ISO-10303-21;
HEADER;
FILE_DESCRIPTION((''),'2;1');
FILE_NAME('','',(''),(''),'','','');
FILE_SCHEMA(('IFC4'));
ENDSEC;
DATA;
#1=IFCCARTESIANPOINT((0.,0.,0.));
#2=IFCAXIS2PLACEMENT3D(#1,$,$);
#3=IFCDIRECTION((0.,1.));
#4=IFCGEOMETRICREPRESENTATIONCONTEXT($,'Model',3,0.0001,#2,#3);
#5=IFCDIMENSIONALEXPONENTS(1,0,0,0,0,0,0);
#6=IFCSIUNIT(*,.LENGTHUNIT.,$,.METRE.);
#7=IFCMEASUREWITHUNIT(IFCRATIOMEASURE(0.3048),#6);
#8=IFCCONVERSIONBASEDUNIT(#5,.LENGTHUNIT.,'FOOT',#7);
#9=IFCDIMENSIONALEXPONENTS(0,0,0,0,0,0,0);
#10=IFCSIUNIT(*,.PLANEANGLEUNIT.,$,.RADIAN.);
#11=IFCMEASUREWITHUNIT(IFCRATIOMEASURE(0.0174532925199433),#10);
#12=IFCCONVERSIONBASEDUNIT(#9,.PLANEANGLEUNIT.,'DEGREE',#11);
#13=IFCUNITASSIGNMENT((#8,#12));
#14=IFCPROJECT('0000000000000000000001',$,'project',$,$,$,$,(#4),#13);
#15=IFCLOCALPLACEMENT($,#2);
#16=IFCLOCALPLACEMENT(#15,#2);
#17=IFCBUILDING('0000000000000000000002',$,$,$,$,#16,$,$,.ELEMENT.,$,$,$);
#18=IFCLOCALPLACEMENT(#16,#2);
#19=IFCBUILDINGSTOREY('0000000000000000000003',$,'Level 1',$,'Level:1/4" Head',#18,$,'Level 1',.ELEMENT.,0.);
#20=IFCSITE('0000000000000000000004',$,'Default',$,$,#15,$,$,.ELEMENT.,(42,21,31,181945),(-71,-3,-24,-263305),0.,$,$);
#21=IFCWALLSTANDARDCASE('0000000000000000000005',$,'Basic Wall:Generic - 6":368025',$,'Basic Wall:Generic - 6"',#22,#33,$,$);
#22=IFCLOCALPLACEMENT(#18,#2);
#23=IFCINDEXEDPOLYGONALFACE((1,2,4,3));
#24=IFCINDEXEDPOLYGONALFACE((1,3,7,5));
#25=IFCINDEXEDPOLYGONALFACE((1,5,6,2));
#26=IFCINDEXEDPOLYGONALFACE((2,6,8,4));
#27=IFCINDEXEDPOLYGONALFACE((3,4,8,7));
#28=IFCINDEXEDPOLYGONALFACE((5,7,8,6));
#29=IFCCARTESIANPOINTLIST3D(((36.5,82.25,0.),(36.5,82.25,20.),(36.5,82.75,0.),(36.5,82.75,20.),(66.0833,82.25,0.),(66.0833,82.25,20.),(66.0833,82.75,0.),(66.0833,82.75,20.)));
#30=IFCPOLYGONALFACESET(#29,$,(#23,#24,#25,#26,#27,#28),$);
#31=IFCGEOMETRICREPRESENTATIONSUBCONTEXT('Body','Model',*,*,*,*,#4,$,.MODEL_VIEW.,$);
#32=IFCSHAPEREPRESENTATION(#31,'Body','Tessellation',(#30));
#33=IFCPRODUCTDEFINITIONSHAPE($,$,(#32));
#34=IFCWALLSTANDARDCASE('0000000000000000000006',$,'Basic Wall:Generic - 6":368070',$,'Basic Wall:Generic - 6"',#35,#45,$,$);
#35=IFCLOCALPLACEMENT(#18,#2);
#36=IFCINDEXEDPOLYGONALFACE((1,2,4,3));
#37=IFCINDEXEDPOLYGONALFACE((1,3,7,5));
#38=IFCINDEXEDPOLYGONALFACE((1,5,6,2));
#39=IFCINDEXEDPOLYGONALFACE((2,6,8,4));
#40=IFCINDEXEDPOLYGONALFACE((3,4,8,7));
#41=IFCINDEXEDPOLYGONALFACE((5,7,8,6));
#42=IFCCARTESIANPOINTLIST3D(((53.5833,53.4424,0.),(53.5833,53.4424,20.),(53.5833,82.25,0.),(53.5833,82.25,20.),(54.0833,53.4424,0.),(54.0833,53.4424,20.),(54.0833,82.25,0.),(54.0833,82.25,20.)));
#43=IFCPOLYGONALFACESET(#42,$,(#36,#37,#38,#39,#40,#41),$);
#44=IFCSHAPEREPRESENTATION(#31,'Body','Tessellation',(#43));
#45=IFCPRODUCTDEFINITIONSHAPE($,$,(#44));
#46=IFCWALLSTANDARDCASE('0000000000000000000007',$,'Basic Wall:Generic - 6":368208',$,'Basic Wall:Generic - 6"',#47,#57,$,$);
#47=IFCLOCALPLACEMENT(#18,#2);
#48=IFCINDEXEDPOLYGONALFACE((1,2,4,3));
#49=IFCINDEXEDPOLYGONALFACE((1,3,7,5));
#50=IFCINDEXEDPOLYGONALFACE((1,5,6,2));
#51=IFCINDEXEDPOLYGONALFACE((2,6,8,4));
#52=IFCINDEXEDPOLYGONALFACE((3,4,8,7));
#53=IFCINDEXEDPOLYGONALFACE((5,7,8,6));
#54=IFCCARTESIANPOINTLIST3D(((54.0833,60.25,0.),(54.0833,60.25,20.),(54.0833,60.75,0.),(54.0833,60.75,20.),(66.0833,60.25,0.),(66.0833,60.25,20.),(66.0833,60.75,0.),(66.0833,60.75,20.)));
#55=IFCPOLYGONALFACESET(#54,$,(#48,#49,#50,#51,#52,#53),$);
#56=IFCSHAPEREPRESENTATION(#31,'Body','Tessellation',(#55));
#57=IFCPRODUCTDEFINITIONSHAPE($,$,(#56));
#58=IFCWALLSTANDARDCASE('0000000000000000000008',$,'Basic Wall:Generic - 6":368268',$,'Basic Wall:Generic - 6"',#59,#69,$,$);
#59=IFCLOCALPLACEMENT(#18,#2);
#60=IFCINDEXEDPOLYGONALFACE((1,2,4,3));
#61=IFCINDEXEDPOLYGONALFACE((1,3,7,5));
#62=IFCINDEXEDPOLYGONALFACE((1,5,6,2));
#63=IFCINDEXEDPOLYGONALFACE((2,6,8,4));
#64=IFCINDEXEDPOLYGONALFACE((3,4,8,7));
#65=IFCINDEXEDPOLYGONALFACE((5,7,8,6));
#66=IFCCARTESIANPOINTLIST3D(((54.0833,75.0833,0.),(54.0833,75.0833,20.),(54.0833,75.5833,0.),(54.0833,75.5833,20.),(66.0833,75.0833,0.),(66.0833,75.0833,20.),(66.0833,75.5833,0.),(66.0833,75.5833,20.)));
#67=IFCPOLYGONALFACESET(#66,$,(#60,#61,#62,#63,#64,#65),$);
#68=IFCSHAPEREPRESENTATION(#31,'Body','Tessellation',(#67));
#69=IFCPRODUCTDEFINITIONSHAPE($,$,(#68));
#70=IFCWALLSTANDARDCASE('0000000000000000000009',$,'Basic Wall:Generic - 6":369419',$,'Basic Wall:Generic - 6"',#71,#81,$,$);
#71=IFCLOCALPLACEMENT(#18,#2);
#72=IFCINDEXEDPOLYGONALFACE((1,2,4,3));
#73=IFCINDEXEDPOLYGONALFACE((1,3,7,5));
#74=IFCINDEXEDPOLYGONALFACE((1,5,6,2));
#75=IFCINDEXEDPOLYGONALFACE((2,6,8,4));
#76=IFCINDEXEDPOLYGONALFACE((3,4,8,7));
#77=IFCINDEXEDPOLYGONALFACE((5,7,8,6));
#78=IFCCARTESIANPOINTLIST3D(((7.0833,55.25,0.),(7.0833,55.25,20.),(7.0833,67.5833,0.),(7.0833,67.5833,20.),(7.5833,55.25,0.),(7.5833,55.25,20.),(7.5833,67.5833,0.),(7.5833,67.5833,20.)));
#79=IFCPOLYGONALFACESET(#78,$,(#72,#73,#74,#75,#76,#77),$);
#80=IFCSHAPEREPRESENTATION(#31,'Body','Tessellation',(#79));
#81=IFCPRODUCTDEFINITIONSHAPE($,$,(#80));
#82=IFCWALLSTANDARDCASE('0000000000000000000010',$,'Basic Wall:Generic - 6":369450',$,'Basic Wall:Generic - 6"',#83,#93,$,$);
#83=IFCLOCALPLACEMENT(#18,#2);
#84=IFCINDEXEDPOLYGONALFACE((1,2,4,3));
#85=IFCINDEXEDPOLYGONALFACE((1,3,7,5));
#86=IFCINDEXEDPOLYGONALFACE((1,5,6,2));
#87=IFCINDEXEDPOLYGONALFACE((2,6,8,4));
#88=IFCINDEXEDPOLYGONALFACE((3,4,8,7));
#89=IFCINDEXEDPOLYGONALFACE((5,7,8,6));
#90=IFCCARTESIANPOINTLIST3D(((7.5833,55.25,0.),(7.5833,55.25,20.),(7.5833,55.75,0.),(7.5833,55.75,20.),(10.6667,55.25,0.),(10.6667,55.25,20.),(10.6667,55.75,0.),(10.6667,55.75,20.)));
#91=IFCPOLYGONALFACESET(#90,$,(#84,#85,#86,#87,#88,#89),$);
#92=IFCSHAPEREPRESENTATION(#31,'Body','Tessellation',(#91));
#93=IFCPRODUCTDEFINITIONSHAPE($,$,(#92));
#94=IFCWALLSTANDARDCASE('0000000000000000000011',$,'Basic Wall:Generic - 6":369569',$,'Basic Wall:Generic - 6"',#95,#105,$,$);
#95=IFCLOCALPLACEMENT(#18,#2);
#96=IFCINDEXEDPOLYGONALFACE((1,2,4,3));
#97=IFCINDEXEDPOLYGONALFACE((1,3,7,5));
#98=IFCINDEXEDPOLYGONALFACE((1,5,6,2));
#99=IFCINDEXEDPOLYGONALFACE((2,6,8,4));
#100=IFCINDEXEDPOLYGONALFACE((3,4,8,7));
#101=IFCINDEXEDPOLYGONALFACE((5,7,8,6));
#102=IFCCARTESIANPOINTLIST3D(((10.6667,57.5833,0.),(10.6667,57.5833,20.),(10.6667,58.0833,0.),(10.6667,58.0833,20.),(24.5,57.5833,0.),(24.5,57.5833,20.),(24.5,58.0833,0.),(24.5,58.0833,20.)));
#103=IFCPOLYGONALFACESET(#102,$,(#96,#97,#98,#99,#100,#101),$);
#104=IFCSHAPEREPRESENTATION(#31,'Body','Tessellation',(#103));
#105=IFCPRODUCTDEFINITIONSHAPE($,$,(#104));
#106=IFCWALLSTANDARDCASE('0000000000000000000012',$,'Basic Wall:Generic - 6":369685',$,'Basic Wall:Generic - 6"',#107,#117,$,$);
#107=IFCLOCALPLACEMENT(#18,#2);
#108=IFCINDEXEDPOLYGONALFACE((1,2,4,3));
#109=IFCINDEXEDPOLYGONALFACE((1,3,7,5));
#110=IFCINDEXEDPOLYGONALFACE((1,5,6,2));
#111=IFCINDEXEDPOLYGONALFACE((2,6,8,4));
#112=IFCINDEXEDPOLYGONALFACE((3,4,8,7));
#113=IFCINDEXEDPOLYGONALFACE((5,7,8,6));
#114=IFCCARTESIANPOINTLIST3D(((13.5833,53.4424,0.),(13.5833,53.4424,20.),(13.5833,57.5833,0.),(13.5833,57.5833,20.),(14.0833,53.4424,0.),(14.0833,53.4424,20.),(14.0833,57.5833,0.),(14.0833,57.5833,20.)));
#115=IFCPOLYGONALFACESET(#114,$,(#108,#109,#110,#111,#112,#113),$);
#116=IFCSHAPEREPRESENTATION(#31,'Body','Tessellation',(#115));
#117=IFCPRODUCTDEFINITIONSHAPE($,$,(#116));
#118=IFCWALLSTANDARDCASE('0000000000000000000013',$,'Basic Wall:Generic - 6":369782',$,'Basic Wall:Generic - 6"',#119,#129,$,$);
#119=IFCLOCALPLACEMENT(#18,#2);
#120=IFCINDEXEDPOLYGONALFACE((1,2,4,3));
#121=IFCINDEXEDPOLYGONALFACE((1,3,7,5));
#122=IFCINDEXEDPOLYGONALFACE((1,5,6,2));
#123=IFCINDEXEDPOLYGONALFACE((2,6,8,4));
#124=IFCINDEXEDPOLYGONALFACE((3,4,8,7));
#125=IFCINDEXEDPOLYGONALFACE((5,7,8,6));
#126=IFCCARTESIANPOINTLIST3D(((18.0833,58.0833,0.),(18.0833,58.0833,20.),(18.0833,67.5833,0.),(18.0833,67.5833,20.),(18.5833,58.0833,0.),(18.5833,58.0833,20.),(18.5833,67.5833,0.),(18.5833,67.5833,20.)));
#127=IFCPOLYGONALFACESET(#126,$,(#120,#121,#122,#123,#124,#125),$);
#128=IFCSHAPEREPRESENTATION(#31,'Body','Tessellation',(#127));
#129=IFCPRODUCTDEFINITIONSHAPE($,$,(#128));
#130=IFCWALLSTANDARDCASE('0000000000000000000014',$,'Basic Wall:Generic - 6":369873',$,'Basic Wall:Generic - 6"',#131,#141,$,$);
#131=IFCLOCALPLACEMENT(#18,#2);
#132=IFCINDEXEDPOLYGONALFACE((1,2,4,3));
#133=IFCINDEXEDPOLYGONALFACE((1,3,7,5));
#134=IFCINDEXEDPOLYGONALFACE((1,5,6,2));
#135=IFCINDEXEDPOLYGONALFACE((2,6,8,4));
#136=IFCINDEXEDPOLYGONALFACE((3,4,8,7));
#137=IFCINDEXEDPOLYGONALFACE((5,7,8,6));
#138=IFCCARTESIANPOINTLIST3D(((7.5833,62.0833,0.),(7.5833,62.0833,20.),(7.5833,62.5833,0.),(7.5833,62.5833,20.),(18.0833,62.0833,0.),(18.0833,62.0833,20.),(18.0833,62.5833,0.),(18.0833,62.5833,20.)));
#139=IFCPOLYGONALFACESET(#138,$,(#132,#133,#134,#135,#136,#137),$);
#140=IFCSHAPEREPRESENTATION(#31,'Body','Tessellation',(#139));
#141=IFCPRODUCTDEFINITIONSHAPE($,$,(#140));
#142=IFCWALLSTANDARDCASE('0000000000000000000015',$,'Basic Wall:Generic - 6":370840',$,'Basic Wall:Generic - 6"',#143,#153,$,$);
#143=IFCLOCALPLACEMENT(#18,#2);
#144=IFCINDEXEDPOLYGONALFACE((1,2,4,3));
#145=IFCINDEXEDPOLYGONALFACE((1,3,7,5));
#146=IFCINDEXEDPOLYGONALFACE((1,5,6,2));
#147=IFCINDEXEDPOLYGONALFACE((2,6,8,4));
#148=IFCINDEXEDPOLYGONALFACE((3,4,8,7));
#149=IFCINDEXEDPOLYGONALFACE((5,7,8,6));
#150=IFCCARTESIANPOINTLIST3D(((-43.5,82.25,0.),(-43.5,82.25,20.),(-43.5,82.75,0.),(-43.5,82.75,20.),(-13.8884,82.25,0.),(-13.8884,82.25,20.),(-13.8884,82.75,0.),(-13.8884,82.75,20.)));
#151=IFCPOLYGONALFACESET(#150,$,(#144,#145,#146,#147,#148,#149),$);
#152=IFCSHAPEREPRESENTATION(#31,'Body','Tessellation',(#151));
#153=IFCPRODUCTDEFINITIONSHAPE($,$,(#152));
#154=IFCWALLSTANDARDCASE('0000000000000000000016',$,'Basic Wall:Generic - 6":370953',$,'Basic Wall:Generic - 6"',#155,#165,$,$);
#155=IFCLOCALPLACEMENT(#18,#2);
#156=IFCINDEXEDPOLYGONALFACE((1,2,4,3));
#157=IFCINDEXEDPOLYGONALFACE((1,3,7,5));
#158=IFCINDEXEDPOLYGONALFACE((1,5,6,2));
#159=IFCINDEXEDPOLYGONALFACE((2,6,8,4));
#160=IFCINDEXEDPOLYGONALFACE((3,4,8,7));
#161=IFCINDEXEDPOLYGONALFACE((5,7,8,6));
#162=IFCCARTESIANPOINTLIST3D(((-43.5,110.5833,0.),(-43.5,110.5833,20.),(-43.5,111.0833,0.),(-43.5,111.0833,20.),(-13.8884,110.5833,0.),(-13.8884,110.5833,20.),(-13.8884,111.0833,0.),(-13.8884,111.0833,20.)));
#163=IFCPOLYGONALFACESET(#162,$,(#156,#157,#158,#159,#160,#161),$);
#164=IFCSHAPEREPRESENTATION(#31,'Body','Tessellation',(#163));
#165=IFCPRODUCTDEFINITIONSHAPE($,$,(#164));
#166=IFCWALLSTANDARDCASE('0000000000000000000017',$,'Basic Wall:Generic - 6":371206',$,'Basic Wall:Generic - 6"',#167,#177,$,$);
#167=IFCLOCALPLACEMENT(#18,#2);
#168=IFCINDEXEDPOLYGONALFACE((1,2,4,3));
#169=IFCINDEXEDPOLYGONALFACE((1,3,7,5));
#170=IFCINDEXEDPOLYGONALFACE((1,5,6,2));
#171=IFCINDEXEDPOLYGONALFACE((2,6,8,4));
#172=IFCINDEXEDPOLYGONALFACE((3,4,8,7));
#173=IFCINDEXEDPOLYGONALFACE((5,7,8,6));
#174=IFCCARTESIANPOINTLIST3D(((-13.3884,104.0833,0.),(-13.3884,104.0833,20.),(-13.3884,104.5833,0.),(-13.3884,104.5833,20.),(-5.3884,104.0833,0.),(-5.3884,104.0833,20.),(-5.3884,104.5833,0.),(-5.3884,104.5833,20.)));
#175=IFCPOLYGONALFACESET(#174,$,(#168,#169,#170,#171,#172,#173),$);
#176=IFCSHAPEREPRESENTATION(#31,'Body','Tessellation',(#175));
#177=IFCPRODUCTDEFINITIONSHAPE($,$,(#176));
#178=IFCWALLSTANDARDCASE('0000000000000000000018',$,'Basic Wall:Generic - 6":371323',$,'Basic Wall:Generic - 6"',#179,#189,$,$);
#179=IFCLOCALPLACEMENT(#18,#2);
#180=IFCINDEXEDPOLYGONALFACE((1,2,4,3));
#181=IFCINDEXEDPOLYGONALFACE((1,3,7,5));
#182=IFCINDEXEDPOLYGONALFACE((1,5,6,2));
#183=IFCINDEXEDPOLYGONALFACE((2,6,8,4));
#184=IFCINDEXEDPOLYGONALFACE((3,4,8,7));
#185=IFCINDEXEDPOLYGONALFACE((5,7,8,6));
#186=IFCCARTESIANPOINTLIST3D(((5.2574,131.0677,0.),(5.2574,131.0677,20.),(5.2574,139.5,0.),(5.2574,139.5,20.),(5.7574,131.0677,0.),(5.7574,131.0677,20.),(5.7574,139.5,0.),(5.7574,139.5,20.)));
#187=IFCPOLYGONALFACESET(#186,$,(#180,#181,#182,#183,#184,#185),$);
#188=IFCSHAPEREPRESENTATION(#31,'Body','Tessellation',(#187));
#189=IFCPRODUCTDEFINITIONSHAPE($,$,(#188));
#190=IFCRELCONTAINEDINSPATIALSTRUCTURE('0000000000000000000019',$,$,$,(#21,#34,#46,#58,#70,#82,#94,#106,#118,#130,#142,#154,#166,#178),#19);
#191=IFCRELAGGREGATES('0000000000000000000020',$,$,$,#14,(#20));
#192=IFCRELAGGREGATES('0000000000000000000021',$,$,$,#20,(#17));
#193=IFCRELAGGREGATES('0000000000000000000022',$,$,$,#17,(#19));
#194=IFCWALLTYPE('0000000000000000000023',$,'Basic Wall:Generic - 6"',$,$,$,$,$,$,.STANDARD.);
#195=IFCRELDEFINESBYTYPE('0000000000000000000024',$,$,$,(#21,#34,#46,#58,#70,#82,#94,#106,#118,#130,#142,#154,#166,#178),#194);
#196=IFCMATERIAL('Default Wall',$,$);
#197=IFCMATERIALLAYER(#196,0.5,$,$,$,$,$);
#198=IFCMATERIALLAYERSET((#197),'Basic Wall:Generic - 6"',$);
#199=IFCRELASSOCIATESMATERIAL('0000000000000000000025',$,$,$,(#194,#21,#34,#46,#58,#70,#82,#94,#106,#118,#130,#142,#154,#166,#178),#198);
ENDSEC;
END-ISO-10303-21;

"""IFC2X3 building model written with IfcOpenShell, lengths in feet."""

from ifc_helpers import new_model, entity, si_unit, converted_unit, direction, frame, frame_2d, origin, place, context, subcontext, project, spatial, rectangle, extrude, material, layer, layer_set, layer_usage, type_object, element, save


model = new_model("IFC2X3")

# Units and contexts
model_context = context("Model", 3, precision=0.0001, world=origin(), true_north=direction((0.0, 1.0)))
body_context = subcontext(model_context, "Body", "Model", "MODEL_VIEW")
ifc_project = project(units=[converted_unit("LENGTHUNIT", "FOOT", entity("IfcRatioMeasure", 0.3048), si_unit("LENGTHUNIT", "METRE"), dimensions=[1, 0, 0, 0, 0, 0, 0]), converted_unit("PLANEANGLEUNIT", "DEGREE", entity("IfcRatioMeasure", 0.0174532925199433), si_unit("PLANEANGLEUNIT", "RADIAN"), dimensions=[0, 0, 0, 0, 0, 0, 0])], contexts=[model_context])

# Site, building, storey
site_placement = place(None, origin())
site = spatial("IfcSite", under=ifc_project, at=site_placement, Name="Default", CompositionType="ELEMENT", RefLatitude=(42, 21, 31, 181945), RefLongitude=(-71, -3, -24, -263305), RefElevation=0.0)
building_placement = place(site_placement, origin())
building = spatial("IfcBuilding", under=site, at=building_placement, CompositionType="ELEMENT")
storey_placement = place(building_placement, origin())
storey = spatial("IfcBuildingStorey", under=building, at=storey_placement, Name="Level 1", ObjectType="Level:1/4\" Head", LongName="Level 1", CompositionType="ELEMENT", Elevation=0.0)

# Walls
ifc_material = material(Name="Default Wall")
ifc_layer_1 = layer(ifc_material, 0.5)
ifc_layer_set_1 = layer_set([ifc_layer_1], Name="Basic Wall:Generic - 6\"")
wall_type_1 = type_object("IfcWallType", Name="Basic Wall:Generic - 6\"", PredefinedType="STANDARD", material=ifc_layer_set_1)
ifc_layer_usage_1 = layer_usage(ifc_layer_set_1, "AXIS2", "NEGATIVE", 0.25)
wall_1_placement = place(storey_placement, frame((36.5, 82.5, 0.0)))
element("IfcWallStandardCase", 1, at=wall_1_placement, inside=storey, type_object=wall_type_1, material=ifc_layer_usage_1, Name="Basic Wall:Generic - 6\":368025", ObjectType="Basic Wall:Generic - 6\"", context=body_context, shape_type="SweptSolid", body=[
    extrude(rectangle(XDim=29.5833, YDim=0.5, at=frame_2d((14.7917, 0.0), x_axis=(-1.0, 0.0))), origin(), (0.0, 0.0, 1.0), 20.0),
])
ifc_layer_usage_2 = layer_usage(ifc_layer_set_1, "AXIS2", "NEGATIVE", 0.25)
wall_2_placement = place(storey_placement, frame((53.8333, 82.25, 0.0), z_axis=(0.0, 0.0, 1.0), x_axis=(0.0, -1.0, 0.0)))
element("IfcWallStandardCase", 2, at=wall_2_placement, inside=storey, type_object=wall_type_1, material=ifc_layer_usage_2, Name="Basic Wall:Generic - 6\":368070", ObjectType="Basic Wall:Generic - 6\"", context=body_context, shape_type="SweptSolid", body=[
    extrude(rectangle(XDim=28.8076, YDim=0.5, at=frame_2d((14.4038, 0.0), x_axis=(-1.0, 0.0))), origin(), (0.0, 0.0, 1.0), 20.0),
])
ifc_layer_usage_3 = layer_usage(ifc_layer_set_1, "AXIS2", "NEGATIVE", 0.25)
wall_3_placement = place(storey_placement, frame((54.0833, 60.5, 0.0)))
element("IfcWallStandardCase", 3, at=wall_3_placement, inside=storey, type_object=wall_type_1, material=ifc_layer_usage_3, Name="Basic Wall:Generic - 6\":368208", ObjectType="Basic Wall:Generic - 6\"", context=body_context, shape_type="SweptSolid", body=[
    extrude(rectangle(XDim=12.0, YDim=0.5, at=frame_2d((6.0, 0.0), x_axis=(-1.0, 0.0))), origin(), (0.0, 0.0, 1.0), 20.0),
])
ifc_layer_usage_4 = layer_usage(ifc_layer_set_1, "AXIS2", "NEGATIVE", 0.25)
wall_4_placement = place(storey_placement, frame((54.0833, 75.3333, 0.0)))
element("IfcWallStandardCase", 4, at=wall_4_placement, inside=storey, type_object=wall_type_1, material=ifc_layer_usage_4, Name="Basic Wall:Generic - 6\":368268", ObjectType="Basic Wall:Generic - 6\"", context=body_context, shape_type="SweptSolid", body=[
    extrude(rectangle(XDim=12.0, YDim=0.5, at=frame_2d((6.0, 0.0), x_axis=(-1.0, 0.0))), origin(), (0.0, 0.0, 1.0), 20.0),
])
ifc_layer_usage_5 = layer_usage(ifc_layer_set_1, "AXIS2", "NEGATIVE", 0.25)
wall_5_placement = place(storey_placement, frame((7.3333, 67.5833, 0.0), z_axis=(0.0, 0.0, 1.0), x_axis=(0.0, -1.0, 0.0)))
element("IfcWallStandardCase", 5, at=wall_5_placement, inside=storey, type_object=wall_type_1, material=ifc_layer_usage_5, Name="Basic Wall:Generic - 6\":369419", ObjectType="Basic Wall:Generic - 6\"", context=body_context, shape_type="SweptSolid", body=[
    extrude(rectangle(XDim=12.3333, YDim=0.5, at=frame_2d((6.1667, 0.0), x_axis=(-1.0, 0.0))), origin(), (0.0, 0.0, 1.0), 20.0),
])
ifc_layer_usage_6 = layer_usage(ifc_layer_set_1, "AXIS2", "NEGATIVE", 0.25)
wall_6_placement = place(storey_placement, frame((7.5833, 55.5, 0.0)))
element("IfcWallStandardCase", 6, at=wall_6_placement, inside=storey, type_object=wall_type_1, material=ifc_layer_usage_6, Name="Basic Wall:Generic - 6\":369450", ObjectType="Basic Wall:Generic - 6\"", context=body_context, shape_type="SweptSolid", body=[
    extrude(rectangle(XDim=3.0833, YDim=0.5, at=frame_2d((1.5417, 0.0), x_axis=(-1.0, 0.0))), origin(), (0.0, 0.0, 1.0), 20.0),
])
ifc_layer_usage_7 = layer_usage(ifc_layer_set_1, "AXIS2", "NEGATIVE", 0.25)
wall_7_placement = place(storey_placement, frame((10.6667, 57.8333, 0.0)))
element("IfcWallStandardCase", 7, at=wall_7_placement, inside=storey, type_object=wall_type_1, material=ifc_layer_usage_7, Name="Basic Wall:Generic - 6\":369569", ObjectType="Basic Wall:Generic - 6\"", context=body_context, shape_type="SweptSolid", body=[
    extrude(rectangle(XDim=13.8333, YDim=0.5, at=frame_2d((6.9167, 0.0), x_axis=(-1.0, 0.0))), origin(), (0.0, 0.0, 1.0), 20.0),
])
ifc_layer_usage_8 = layer_usage(ifc_layer_set_1, "AXIS2", "NEGATIVE", 0.25)
wall_8_placement = place(storey_placement, frame((13.8333, 57.5833, 0.0), z_axis=(0.0, 0.0, 1.0), x_axis=(0.0, -1.0, 0.0)))
element("IfcWallStandardCase", 8, at=wall_8_placement, inside=storey, type_object=wall_type_1, material=ifc_layer_usage_8, Name="Basic Wall:Generic - 6\":369685", ObjectType="Basic Wall:Generic - 6\"", context=body_context, shape_type="SweptSolid", body=[
    extrude(rectangle(XDim=4.141, YDim=0.5, at=frame_2d((2.0705, 0.0), x_axis=(-1.0, 0.0))), origin(), (0.0, 0.0, 1.0), 20.0),
])
ifc_layer_usage_9 = layer_usage(ifc_layer_set_1, "AXIS2", "NEGATIVE", 0.25)
wall_9_placement = place(storey_placement, frame((18.3333, 67.5833, 0.0), z_axis=(0.0, 0.0, 1.0), x_axis=(0.0, -1.0, 0.0)))
element("IfcWallStandardCase", 9, at=wall_9_placement, inside=storey, type_object=wall_type_1, material=ifc_layer_usage_9, Name="Basic Wall:Generic - 6\":369782", ObjectType="Basic Wall:Generic - 6\"", context=body_context, shape_type="SweptSolid", body=[
    extrude(rectangle(XDim=9.5, YDim=0.5, at=frame_2d((4.75, 0.0), x_axis=(-1.0, 0.0))), origin(), (0.0, 0.0, 1.0), 20.0),
])
ifc_layer_usage_10 = layer_usage(ifc_layer_set_1, "AXIS2", "NEGATIVE", 0.25)
wall_10_placement = place(storey_placement, frame((7.5833, 62.3333, 0.0)))
element("IfcWallStandardCase", 10, at=wall_10_placement, inside=storey, type_object=wall_type_1, material=ifc_layer_usage_10, Name="Basic Wall:Generic - 6\":369873", ObjectType="Basic Wall:Generic - 6\"", context=body_context, shape_type="SweptSolid", body=[
    extrude(rectangle(XDim=10.5, YDim=0.5, at=frame_2d((5.25, 0.0), x_axis=(-1.0, 0.0))), origin(), (0.0, 0.0, 1.0), 20.0),
])
ifc_layer_usage_11 = layer_usage(ifc_layer_set_1, "AXIS2", "NEGATIVE", 0.25)
wall_11_placement = place(storey_placement, frame((-13.8884, 82.5, 0.0), z_axis=(0.0, 0.0, 1.0), x_axis=(-1.0, 0.0, 0.0)))
element("IfcWallStandardCase", 11, at=wall_11_placement, inside=storey, type_object=wall_type_1, material=ifc_layer_usage_11, Name="Basic Wall:Generic - 6\":370840", ObjectType="Basic Wall:Generic - 6\"", context=body_context, shape_type="SweptSolid", body=[
    extrude(rectangle(XDim=29.6116, YDim=0.5, at=frame_2d((14.8058, 0.0), x_axis=(-1.0, 0.0))), origin(), (0.0, 0.0, 1.0), 20.0),
])
ifc_layer_usage_12 = layer_usage(ifc_layer_set_1, "AXIS2", "NEGATIVE", 0.25)
wall_12_placement = place(storey_placement, frame((-13.8884, 110.8333, 0.0), z_axis=(0.0, 0.0, 1.0), x_axis=(-1.0, 0.0, 0.0)))
element("IfcWallStandardCase", 12, at=wall_12_placement, inside=storey, type_object=wall_type_1, material=ifc_layer_usage_12, Name="Basic Wall:Generic - 6\":370953", ObjectType="Basic Wall:Generic - 6\"", context=body_context, shape_type="SweptSolid", body=[
    extrude(rectangle(XDim=29.6116, YDim=0.5, at=frame_2d((14.8058, 0.0), x_axis=(-1.0, 0.0))), origin(), (0.0, 0.0, 1.0), 20.0),
])
ifc_layer_usage_13 = layer_usage(ifc_layer_set_1, "AXIS2", "NEGATIVE", 0.25)
wall_13_placement = place(storey_placement, frame((-13.3884, 104.3333, 0.0)))
element("IfcWallStandardCase", 13, at=wall_13_placement, inside=storey, type_object=wall_type_1, material=ifc_layer_usage_13, Name="Basic Wall:Generic - 6\":371206", ObjectType="Basic Wall:Generic - 6\"", context=body_context, shape_type="SweptSolid", body=[
    extrude(rectangle(XDim=8.0, YDim=0.5, at=frame_2d((4.0, 0.0), x_axis=(-1.0, 0.0))), origin(), (0.0, 0.0, 1.0), 20.0),
])
ifc_layer_usage_14 = layer_usage(ifc_layer_set_1, "AXIS2", "NEGATIVE", 0.25)
wall_14_placement = place(storey_placement, frame((5.5074, 139.5, 0.0), z_axis=(0.0, 0.0, 1.0), x_axis=(0.0, -1.0, 0.0)))
element("IfcWallStandardCase", 14, at=wall_14_placement, inside=storey, type_object=wall_type_1, material=ifc_layer_usage_14, Name="Basic Wall:Generic - 6\":371323", ObjectType="Basic Wall:Generic - 6\"", context=body_context, shape_type="SweptSolid", body=[
    extrude(rectangle(XDim=8.4323, YDim=0.5, at=frame_2d((4.2161, 0.0), x_axis=(-1.0, 0.0))), origin(), (0.0, 0.0, 1.0), 20.0),
])

save(model, "model.ifc")
